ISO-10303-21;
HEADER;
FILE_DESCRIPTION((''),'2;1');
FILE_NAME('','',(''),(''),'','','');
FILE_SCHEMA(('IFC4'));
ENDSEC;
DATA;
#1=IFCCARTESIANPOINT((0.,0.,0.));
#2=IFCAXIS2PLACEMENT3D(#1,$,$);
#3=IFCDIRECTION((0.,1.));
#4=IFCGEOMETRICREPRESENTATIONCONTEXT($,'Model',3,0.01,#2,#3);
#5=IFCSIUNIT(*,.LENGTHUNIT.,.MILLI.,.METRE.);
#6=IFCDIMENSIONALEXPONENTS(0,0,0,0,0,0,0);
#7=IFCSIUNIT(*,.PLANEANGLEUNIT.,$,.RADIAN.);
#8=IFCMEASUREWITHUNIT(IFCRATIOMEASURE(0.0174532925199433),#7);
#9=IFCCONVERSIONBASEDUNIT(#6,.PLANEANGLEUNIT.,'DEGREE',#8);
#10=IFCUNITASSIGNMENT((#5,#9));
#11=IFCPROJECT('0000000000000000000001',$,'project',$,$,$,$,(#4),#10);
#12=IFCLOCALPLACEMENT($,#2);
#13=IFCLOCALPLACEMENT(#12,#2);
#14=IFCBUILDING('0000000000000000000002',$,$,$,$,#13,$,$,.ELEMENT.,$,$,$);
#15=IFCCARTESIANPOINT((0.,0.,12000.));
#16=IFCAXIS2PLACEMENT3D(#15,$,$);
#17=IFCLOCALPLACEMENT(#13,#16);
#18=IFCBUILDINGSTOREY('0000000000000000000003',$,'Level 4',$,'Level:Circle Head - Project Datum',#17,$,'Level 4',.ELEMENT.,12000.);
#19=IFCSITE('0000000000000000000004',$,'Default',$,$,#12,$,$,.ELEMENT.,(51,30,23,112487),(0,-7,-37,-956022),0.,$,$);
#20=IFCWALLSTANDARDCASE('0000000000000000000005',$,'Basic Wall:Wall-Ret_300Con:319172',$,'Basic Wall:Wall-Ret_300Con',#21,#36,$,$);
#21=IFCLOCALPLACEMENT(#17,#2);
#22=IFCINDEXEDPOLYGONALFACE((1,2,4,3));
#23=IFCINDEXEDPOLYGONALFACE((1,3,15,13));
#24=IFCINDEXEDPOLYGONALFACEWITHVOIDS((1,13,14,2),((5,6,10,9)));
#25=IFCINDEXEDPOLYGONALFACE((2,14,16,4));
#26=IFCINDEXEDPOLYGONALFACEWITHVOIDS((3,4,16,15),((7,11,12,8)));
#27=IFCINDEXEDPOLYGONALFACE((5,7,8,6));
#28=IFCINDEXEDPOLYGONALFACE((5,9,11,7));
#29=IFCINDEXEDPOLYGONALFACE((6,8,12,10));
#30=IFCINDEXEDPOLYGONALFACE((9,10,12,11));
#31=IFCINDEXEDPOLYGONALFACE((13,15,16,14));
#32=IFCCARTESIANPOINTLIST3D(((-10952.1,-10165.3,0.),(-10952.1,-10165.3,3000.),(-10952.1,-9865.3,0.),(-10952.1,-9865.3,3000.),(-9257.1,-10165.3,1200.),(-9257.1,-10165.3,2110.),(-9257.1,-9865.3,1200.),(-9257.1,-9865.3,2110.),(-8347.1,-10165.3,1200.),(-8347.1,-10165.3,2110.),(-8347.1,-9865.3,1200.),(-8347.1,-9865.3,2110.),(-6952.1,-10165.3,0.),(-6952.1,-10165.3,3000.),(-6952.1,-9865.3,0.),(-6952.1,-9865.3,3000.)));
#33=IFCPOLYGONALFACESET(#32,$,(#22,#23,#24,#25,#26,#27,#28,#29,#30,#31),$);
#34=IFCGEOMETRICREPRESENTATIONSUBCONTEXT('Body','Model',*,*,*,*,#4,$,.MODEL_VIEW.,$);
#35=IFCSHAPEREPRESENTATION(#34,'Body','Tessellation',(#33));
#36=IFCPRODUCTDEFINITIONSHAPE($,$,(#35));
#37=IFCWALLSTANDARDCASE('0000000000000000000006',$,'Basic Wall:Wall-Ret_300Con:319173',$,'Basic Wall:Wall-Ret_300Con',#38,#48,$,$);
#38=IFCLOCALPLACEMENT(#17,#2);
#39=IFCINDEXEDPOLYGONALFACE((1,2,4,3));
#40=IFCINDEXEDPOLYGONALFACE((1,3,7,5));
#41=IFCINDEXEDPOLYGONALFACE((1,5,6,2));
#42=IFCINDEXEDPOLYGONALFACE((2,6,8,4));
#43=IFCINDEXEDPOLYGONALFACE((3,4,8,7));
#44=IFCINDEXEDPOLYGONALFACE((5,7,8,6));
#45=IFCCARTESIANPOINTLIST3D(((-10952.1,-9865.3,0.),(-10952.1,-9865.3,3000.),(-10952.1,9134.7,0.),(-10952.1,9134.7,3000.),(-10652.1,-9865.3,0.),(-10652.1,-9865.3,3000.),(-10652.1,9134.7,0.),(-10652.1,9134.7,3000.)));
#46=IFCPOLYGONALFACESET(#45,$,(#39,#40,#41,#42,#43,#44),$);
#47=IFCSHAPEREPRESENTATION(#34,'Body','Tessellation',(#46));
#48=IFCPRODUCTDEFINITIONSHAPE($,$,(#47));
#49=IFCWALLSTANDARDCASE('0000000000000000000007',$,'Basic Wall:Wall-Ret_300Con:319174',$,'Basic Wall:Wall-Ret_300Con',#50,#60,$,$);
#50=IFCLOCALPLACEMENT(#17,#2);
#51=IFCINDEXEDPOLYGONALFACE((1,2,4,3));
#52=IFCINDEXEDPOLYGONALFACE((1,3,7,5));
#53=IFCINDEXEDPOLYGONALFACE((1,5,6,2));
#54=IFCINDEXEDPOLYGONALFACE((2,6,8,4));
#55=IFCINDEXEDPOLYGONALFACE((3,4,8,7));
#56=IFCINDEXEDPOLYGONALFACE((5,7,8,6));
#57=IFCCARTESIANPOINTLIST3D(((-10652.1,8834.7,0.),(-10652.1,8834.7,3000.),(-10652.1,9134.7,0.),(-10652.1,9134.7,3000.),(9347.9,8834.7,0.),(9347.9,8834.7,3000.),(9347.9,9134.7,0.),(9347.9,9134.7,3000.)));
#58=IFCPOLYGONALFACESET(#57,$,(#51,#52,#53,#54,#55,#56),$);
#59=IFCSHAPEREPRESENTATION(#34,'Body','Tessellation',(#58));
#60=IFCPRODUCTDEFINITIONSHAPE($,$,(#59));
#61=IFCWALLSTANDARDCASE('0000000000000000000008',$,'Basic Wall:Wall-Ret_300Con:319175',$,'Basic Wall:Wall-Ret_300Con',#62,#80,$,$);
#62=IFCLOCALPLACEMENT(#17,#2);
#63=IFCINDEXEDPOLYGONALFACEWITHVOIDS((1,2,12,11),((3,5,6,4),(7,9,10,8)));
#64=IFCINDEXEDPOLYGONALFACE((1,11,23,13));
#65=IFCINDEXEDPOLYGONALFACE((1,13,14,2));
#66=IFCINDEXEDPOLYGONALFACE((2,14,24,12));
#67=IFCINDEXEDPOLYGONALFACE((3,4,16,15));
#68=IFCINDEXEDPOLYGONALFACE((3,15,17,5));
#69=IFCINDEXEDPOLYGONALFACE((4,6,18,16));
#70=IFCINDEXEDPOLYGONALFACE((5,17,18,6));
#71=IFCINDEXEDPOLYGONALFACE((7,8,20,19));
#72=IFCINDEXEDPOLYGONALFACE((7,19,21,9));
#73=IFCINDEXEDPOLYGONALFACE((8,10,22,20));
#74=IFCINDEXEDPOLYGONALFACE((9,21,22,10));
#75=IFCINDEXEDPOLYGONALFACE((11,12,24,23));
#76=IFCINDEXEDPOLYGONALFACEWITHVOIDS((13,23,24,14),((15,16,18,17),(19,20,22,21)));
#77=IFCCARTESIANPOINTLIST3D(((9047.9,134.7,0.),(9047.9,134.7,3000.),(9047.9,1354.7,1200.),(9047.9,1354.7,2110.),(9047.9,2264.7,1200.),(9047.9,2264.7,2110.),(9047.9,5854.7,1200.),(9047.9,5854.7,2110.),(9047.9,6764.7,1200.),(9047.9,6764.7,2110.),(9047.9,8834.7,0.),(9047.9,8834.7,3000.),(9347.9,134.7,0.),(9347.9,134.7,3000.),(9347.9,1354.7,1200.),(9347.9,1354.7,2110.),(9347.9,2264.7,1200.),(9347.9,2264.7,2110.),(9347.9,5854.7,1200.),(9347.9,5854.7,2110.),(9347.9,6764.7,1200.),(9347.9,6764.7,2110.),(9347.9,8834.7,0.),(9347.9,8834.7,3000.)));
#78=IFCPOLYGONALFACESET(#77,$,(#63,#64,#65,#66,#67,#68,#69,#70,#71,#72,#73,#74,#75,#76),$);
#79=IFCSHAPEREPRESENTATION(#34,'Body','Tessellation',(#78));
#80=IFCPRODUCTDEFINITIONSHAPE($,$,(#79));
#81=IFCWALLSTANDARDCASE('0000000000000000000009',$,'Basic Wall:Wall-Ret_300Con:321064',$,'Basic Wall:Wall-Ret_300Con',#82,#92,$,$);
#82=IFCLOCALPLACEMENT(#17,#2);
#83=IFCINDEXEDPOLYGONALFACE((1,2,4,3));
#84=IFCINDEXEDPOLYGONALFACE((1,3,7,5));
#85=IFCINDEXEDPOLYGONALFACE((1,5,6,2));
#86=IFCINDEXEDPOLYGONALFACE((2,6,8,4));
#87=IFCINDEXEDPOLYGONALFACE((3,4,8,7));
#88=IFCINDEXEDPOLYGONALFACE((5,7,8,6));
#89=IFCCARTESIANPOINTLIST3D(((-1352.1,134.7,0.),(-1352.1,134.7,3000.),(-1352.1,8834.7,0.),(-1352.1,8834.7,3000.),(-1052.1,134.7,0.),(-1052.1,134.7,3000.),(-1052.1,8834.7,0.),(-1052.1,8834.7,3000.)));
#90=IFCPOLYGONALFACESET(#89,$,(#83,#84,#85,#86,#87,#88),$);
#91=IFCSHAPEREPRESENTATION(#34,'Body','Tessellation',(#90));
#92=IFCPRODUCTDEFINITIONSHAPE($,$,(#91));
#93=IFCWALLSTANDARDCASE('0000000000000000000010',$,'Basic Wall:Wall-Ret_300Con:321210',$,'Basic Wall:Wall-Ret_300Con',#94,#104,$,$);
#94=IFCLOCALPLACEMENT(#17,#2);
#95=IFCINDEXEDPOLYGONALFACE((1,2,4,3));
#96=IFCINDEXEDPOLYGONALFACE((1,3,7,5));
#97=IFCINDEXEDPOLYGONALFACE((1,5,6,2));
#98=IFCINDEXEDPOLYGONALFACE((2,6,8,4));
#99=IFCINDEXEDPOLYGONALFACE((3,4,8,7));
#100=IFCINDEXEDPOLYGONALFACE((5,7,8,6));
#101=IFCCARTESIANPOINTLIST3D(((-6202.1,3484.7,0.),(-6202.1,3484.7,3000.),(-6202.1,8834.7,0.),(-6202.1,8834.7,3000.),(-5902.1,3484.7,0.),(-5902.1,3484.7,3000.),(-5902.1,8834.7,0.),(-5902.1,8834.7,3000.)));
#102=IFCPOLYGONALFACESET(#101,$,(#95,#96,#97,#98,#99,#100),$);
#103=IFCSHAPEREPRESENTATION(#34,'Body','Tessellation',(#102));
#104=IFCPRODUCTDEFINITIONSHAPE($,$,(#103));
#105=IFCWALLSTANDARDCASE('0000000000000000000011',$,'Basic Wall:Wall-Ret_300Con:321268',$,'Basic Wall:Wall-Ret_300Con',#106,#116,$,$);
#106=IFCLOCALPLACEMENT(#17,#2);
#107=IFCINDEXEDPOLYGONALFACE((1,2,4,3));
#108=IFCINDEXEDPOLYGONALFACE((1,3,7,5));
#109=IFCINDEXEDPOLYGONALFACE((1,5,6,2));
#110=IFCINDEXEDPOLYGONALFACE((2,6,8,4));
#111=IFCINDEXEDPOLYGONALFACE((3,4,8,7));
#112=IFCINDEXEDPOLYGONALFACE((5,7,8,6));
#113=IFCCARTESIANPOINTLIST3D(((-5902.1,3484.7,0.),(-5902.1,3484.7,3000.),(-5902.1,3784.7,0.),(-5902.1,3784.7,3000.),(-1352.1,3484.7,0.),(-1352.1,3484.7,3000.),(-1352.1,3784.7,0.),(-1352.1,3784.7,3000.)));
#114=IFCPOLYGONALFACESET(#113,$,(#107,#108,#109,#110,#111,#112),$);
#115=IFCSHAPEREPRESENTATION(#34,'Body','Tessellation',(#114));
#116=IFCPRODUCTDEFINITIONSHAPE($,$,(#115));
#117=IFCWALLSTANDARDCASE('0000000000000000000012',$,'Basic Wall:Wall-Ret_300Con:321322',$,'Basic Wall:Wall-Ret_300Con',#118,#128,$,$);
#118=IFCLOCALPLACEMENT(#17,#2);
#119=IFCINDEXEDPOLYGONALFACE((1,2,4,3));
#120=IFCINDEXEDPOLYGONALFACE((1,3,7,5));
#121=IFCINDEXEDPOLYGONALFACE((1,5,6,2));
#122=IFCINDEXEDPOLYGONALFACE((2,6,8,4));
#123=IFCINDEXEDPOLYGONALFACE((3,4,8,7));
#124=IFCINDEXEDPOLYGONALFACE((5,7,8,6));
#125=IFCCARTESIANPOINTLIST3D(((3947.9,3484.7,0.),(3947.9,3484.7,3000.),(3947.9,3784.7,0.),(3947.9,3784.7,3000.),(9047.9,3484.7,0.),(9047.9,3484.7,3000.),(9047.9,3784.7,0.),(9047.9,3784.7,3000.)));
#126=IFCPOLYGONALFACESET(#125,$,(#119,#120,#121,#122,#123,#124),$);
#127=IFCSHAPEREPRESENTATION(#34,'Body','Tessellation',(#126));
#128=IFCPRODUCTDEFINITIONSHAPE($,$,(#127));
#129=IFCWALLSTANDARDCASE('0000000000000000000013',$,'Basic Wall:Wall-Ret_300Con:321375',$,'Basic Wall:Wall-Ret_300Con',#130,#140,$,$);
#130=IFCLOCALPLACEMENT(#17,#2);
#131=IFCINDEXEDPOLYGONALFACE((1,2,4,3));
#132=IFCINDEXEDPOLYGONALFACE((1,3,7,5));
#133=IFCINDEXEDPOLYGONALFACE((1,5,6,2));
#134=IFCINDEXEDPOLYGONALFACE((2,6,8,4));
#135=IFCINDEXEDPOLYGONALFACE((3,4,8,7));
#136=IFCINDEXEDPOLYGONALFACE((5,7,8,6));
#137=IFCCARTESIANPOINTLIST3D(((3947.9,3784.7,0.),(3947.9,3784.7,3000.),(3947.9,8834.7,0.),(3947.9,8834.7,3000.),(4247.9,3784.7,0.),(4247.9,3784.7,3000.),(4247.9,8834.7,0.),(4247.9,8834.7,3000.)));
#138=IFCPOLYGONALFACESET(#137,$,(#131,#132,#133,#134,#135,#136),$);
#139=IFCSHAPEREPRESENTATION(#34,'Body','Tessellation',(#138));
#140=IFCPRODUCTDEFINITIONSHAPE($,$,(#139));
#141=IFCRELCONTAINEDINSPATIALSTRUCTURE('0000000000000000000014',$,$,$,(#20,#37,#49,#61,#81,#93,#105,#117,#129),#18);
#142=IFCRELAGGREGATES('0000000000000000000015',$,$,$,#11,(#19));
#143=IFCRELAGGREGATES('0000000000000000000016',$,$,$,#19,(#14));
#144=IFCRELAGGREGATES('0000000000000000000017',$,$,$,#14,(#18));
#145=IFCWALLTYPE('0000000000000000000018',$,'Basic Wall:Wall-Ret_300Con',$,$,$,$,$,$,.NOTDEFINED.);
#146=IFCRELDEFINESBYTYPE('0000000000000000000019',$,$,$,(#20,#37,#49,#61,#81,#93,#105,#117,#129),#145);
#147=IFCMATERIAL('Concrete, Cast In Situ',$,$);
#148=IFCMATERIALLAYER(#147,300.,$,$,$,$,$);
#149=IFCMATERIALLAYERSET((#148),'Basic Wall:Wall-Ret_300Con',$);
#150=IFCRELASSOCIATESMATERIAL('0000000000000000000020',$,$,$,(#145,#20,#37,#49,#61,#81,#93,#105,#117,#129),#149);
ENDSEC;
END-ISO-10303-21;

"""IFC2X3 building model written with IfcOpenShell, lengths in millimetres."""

from ifc_helpers import new_model, entity, si_unit, converted_unit, direction, frame, frame_2d, origin, place, context, subcontext, project, spatial, rectangle, extrude, material, layer, layer_set, layer_usage, type_object, element, save


model = new_model("IFC2X3")

# Units and contexts
model_context = context("Model", 3, precision=0.01, world=origin(), true_north=direction((0.0, 1.0)))
body_context = subcontext(model_context, "Body", "Model", "MODEL_VIEW")
ifc_project = project(units=[si_unit("LENGTHUNIT", "METRE", prefix="MILLI"), converted_unit("PLANEANGLEUNIT", "DEGREE", entity("IfcRatioMeasure", 0.0174532925199433), si_unit("PLANEANGLEUNIT", "RADIAN"), dimensions=[0, 0, 0, 0, 0, 0, 0])], contexts=[model_context])

# Site, building, storey
site_placement = place(None, origin())
site = spatial("IfcSite", under=ifc_project, at=site_placement, Name="Default", CompositionType="ELEMENT", RefLatitude=(51, 30, 23, 112487), RefLongitude=(0, -7, -37, -956022), RefElevation=0.0)
building_placement = place(site_placement, origin())
building = spatial("IfcBuilding", under=site, at=building_placement, CompositionType="ELEMENT")
storey_placement = place(building_placement, frame((0.0, 0.0, 12000.0)))
storey = spatial("IfcBuildingStorey", under=building, at=storey_placement, Name="Level 4", ObjectType="Level:Circle Head - Project Datum", LongName="Level 4", CompositionType="ELEMENT", Elevation=12000.0)

# Shared definitions
ifc_material_1 = material(Name="Concrete, Cast In Situ")
ifc_layer_1 = layer(ifc_material_1, 300.0)
ifc_layer_set_1 = layer_set([ifc_layer_1], Name="Basic Wall:Wall-Ret_300Con")
wall_type = type_object("IfcWallType", Name="Basic Wall:Wall-Ret_300Con", PredefinedType="NOTDEFINED", material=ifc_layer_set_1)

# Wall, opening
ifc_layer_usage_1 = layer_usage(ifc_layer_set_1, "AXIS2", "NEGATIVE", 150.0)
wall_1_placement = place(storey_placement, frame((-6952.1, -10015.3, 0.0), z_axis=(0.0, 0.0, 1.0), x_axis=(-1.0, 0.0, 0.0)))
wall_1 = element("IfcWallStandardCase", 1, at=wall_1_placement, inside=storey, type_object=wall_type, material=ifc_layer_usage_1, Name="Basic Wall:Wall-Ret_300Con:319172", ObjectType="Basic Wall:Wall-Ret_300Con", context=body_context, shape_type="SweptSolid", body=[
    extrude(rectangle(XDim=4000.0, YDim=300.0, at=frame_2d((2000.0, 0.0), x_axis=(-1.0, 0.0))), origin(), (0.0, 0.0, 1.0), 3000.0),
])
opening_1_placement = place(wall_1_placement, frame((2305.0, 150.0, 1200.0)))
element("IfcOpeningElement", 2, at=opening_1_placement, cuts=wall_1, ObjectType="Opening", context=body_context, shape_type="SweptSolid", body=[
    extrude(rectangle(XDim=910.0, YDim=910.0, at=frame_2d((455.0, 455.0), x_axis=(-1.0, 0.0))), frame((0.0, 0.0, 0.0), z_axis=(0.0, -1.0, 0.0), x_axis=(0.0, 0.0, 1.0)), (0.0, 0.0, 1.0), 300.0),
])

# Walls
ifc_layer_usage_2 = layer_usage(ifc_layer_set_1, "AXIS2", "NEGATIVE", 150.0)
wall_2_placement = place(storey_placement, frame((-10802.1, -9865.3, 0.0), z_axis=(0.0, 0.0, 1.0), x_axis=(0.0, 1.0, 0.0)))
element("IfcWallStandardCase", 3, at=wall_2_placement, inside=storey, type_object=wall_type, material=ifc_layer_usage_2, Name="Basic Wall:Wall-Ret_300Con:319173", ObjectType="Basic Wall:Wall-Ret_300Con", context=body_context, shape_type="SweptSolid", body=[
    extrude(rectangle(XDim=19000.0, YDim=300.0, at=frame_2d((9500.0, 0.0), x_axis=(-1.0, 0.0))), origin(), (0.0, 0.0, 1.0), 3000.0),
])
ifc_layer_usage_3 = layer_usage(ifc_layer_set_1, "AXIS2", "NEGATIVE", 150.0)
wall_3_placement = place(storey_placement, frame((-10652.1, 8984.7, 0.0)))
element("IfcWallStandardCase", 4, at=wall_3_placement, inside=storey, type_object=wall_type, material=ifc_layer_usage_3, Name="Basic Wall:Wall-Ret_300Con:319174", ObjectType="Basic Wall:Wall-Ret_300Con", context=body_context, shape_type="SweptSolid", body=[
    extrude(rectangle(XDim=20000.0, YDim=300.0, at=frame_2d((10000.0, 0.0), x_axis=(-1.0, 0.0))), origin(), (0.0, 0.0, 1.0), 3000.0),
])

# Wall, openings
ifc_layer_usage_4 = layer_usage(ifc_layer_set_1, "AXIS2", "NEGATIVE", 150.0)
wall_4_placement = place(storey_placement, frame((9197.9, 8834.7, 0.0), z_axis=(0.0, 0.0, 1.0), x_axis=(0.0, -1.0, 0.0)))
wall_4 = element("IfcWallStandardCase", 5, at=wall_4_placement, inside=storey, type_object=wall_type, material=ifc_layer_usage_4, Name="Basic Wall:Wall-Ret_300Con:319175", ObjectType="Basic Wall:Wall-Ret_300Con", context=body_context, shape_type="SweptSolid", body=[
    extrude(rectangle(XDim=8700.0, YDim=300.0, at=frame_2d((4350.0, 0.0), x_axis=(-1.0, 0.0))), origin(), (0.0, 0.0, 1.0), 3000.0),
])
opening_2_placement = place(wall_4_placement, frame((6570.0, -150.0, 1200.0)))
element("IfcOpeningElement", 6, at=opening_2_placement, cuts=wall_4, ObjectType="Opening", context=body_context, shape_type="SweptSolid", body=[
    extrude(rectangle(XDim=910.0, YDim=910.0, at=frame_2d((455.0, 455.0), x_axis=(-1.0, 0.0))), frame((0.0, 0.0, 0.0), z_axis=(0.0, 1.0, 0.0), x_axis=(0.0, 0.0, 1.0)), (0.0, 0.0, 1.0), 300.0),
])
opening_3_placement = place(wall_4_placement, frame((2070.0, -150.0, 1200.0)))
element("IfcOpeningElement", 7, at=opening_3_placement, cuts=wall_4, ObjectType="Opening", context=body_context, shape_type="SweptSolid", body=[
    extrude(rectangle(XDim=910.0, YDim=910.0, at=frame_2d((455.0, 455.0), x_axis=(-1.0, 0.0))), frame((0.0, 0.0, 0.0), z_axis=(0.0, 1.0, 0.0), x_axis=(0.0, 0.0, 1.0)), (0.0, 0.0, 1.0), 300.0),
])

# Walls
ifc_layer_usage_5 = layer_usage(ifc_layer_set_1, "AXIS2", "NEGATIVE", 150.0)
wall_5_placement = place(storey_placement, frame((-1202.1, 134.7, 0.0), z_axis=(0.0, 0.0, 1.0), x_axis=(0.0, 1.0, 0.0)))
element("IfcWallStandardCase", 8, at=wall_5_placement, inside=storey, type_object=wall_type, material=ifc_layer_usage_5, Name="Basic Wall:Wall-Ret_300Con:321064", ObjectType="Basic Wall:Wall-Ret_300Con", context=body_context, shape_type="SweptSolid", body=[
    extrude(rectangle(XDim=8700.0, YDim=300.0, at=frame_2d((4350.0, 0.0), x_axis=(-1.0, 0.0))), origin(), (0.0, 0.0, 1.0), 3000.0),
])
ifc_layer_usage_6 = layer_usage(ifc_layer_set_1, "AXIS2", "NEGATIVE", 150.0)
wall_6_placement = place(storey_placement, frame((-6052.1, 8834.7, 0.0), z_axis=(0.0, 0.0, 1.0), x_axis=(0.0, -1.0, 0.0)))
element("IfcWallStandardCase", 9, at=wall_6_placement, inside=storey, type_object=wall_type, material=ifc_layer_usage_6, Name="Basic Wall:Wall-Ret_300Con:321210", ObjectType="Basic Wall:Wall-Ret_300Con", context=body_context, shape_type="SweptSolid", body=[
    extrude(rectangle(XDim=5350.0, YDim=300.0, at=frame_2d((2675.0, 0.0), x_axis=(-1.0, 0.0))), origin(), (0.0, 0.0, 1.0), 3000.0),
])
ifc_layer_usage_7 = layer_usage(ifc_layer_set_1, "AXIS2", "NEGATIVE", 150.0)
wall_7_placement = place(storey_placement, frame((-5902.1, 3634.7, 0.0)))
element("IfcWallStandardCase", 10, at=wall_7_placement, inside=storey, type_object=wall_type, material=ifc_layer_usage_7, Name="Basic Wall:Wall-Ret_300Con:321268", ObjectType="Basic Wall:Wall-Ret_300Con", context=body_context, shape_type="SweptSolid", body=[
    extrude(rectangle(XDim=4550.0, YDim=300.0, at=frame_2d((2275.0, 0.0), x_axis=(-1.0, 0.0))), origin(), (0.0, 0.0, 1.0), 3000.0),
])
ifc_layer_usage_8 = layer_usage(ifc_layer_set_1, "AXIS2", "NEGATIVE", 150.0)
wall_8_placement = place(storey_placement, frame((9047.9, 3634.7, 0.0), z_axis=(0.0, 0.0, 1.0), x_axis=(-1.0, 0.0, 0.0)))
element("IfcWallStandardCase", 11, at=wall_8_placement, inside=storey, type_object=wall_type, material=ifc_layer_usage_8, Name="Basic Wall:Wall-Ret_300Con:321322", ObjectType="Basic Wall:Wall-Ret_300Con", context=body_context, shape_type="SweptSolid", body=[
    extrude(rectangle(XDim=5100.0, YDim=300.0, at=frame_2d((2550.0, 0.0), x_axis=(-1.0, 0.0))), origin(), (0.0, 0.0, 1.0), 3000.0),
])
ifc_layer_usage_9 = layer_usage(ifc_layer_set_1, "AXIS2", "NEGATIVE", 150.0)
wall_9_placement = place(storey_placement, frame((4097.9, 3784.7, 0.0), z_axis=(0.0, 0.0, 1.0), x_axis=(0.0, 1.0, 0.0)))
element("IfcWallStandardCase", 12, at=wall_9_placement, inside=storey, type_object=wall_type, material=ifc_layer_usage_9, Name="Basic Wall:Wall-Ret_300Con:321375", ObjectType="Basic Wall:Wall-Ret_300Con", context=body_context, shape_type="SweptSolid", body=[
    extrude(rectangle(XDim=5050.0, YDim=300.0, at=frame_2d((2525.0, 0.0), x_axis=(-1.0, 0.0))), origin(), (0.0, 0.0, 1.0), 3000.0),
])

save(model, "model.ifc")
